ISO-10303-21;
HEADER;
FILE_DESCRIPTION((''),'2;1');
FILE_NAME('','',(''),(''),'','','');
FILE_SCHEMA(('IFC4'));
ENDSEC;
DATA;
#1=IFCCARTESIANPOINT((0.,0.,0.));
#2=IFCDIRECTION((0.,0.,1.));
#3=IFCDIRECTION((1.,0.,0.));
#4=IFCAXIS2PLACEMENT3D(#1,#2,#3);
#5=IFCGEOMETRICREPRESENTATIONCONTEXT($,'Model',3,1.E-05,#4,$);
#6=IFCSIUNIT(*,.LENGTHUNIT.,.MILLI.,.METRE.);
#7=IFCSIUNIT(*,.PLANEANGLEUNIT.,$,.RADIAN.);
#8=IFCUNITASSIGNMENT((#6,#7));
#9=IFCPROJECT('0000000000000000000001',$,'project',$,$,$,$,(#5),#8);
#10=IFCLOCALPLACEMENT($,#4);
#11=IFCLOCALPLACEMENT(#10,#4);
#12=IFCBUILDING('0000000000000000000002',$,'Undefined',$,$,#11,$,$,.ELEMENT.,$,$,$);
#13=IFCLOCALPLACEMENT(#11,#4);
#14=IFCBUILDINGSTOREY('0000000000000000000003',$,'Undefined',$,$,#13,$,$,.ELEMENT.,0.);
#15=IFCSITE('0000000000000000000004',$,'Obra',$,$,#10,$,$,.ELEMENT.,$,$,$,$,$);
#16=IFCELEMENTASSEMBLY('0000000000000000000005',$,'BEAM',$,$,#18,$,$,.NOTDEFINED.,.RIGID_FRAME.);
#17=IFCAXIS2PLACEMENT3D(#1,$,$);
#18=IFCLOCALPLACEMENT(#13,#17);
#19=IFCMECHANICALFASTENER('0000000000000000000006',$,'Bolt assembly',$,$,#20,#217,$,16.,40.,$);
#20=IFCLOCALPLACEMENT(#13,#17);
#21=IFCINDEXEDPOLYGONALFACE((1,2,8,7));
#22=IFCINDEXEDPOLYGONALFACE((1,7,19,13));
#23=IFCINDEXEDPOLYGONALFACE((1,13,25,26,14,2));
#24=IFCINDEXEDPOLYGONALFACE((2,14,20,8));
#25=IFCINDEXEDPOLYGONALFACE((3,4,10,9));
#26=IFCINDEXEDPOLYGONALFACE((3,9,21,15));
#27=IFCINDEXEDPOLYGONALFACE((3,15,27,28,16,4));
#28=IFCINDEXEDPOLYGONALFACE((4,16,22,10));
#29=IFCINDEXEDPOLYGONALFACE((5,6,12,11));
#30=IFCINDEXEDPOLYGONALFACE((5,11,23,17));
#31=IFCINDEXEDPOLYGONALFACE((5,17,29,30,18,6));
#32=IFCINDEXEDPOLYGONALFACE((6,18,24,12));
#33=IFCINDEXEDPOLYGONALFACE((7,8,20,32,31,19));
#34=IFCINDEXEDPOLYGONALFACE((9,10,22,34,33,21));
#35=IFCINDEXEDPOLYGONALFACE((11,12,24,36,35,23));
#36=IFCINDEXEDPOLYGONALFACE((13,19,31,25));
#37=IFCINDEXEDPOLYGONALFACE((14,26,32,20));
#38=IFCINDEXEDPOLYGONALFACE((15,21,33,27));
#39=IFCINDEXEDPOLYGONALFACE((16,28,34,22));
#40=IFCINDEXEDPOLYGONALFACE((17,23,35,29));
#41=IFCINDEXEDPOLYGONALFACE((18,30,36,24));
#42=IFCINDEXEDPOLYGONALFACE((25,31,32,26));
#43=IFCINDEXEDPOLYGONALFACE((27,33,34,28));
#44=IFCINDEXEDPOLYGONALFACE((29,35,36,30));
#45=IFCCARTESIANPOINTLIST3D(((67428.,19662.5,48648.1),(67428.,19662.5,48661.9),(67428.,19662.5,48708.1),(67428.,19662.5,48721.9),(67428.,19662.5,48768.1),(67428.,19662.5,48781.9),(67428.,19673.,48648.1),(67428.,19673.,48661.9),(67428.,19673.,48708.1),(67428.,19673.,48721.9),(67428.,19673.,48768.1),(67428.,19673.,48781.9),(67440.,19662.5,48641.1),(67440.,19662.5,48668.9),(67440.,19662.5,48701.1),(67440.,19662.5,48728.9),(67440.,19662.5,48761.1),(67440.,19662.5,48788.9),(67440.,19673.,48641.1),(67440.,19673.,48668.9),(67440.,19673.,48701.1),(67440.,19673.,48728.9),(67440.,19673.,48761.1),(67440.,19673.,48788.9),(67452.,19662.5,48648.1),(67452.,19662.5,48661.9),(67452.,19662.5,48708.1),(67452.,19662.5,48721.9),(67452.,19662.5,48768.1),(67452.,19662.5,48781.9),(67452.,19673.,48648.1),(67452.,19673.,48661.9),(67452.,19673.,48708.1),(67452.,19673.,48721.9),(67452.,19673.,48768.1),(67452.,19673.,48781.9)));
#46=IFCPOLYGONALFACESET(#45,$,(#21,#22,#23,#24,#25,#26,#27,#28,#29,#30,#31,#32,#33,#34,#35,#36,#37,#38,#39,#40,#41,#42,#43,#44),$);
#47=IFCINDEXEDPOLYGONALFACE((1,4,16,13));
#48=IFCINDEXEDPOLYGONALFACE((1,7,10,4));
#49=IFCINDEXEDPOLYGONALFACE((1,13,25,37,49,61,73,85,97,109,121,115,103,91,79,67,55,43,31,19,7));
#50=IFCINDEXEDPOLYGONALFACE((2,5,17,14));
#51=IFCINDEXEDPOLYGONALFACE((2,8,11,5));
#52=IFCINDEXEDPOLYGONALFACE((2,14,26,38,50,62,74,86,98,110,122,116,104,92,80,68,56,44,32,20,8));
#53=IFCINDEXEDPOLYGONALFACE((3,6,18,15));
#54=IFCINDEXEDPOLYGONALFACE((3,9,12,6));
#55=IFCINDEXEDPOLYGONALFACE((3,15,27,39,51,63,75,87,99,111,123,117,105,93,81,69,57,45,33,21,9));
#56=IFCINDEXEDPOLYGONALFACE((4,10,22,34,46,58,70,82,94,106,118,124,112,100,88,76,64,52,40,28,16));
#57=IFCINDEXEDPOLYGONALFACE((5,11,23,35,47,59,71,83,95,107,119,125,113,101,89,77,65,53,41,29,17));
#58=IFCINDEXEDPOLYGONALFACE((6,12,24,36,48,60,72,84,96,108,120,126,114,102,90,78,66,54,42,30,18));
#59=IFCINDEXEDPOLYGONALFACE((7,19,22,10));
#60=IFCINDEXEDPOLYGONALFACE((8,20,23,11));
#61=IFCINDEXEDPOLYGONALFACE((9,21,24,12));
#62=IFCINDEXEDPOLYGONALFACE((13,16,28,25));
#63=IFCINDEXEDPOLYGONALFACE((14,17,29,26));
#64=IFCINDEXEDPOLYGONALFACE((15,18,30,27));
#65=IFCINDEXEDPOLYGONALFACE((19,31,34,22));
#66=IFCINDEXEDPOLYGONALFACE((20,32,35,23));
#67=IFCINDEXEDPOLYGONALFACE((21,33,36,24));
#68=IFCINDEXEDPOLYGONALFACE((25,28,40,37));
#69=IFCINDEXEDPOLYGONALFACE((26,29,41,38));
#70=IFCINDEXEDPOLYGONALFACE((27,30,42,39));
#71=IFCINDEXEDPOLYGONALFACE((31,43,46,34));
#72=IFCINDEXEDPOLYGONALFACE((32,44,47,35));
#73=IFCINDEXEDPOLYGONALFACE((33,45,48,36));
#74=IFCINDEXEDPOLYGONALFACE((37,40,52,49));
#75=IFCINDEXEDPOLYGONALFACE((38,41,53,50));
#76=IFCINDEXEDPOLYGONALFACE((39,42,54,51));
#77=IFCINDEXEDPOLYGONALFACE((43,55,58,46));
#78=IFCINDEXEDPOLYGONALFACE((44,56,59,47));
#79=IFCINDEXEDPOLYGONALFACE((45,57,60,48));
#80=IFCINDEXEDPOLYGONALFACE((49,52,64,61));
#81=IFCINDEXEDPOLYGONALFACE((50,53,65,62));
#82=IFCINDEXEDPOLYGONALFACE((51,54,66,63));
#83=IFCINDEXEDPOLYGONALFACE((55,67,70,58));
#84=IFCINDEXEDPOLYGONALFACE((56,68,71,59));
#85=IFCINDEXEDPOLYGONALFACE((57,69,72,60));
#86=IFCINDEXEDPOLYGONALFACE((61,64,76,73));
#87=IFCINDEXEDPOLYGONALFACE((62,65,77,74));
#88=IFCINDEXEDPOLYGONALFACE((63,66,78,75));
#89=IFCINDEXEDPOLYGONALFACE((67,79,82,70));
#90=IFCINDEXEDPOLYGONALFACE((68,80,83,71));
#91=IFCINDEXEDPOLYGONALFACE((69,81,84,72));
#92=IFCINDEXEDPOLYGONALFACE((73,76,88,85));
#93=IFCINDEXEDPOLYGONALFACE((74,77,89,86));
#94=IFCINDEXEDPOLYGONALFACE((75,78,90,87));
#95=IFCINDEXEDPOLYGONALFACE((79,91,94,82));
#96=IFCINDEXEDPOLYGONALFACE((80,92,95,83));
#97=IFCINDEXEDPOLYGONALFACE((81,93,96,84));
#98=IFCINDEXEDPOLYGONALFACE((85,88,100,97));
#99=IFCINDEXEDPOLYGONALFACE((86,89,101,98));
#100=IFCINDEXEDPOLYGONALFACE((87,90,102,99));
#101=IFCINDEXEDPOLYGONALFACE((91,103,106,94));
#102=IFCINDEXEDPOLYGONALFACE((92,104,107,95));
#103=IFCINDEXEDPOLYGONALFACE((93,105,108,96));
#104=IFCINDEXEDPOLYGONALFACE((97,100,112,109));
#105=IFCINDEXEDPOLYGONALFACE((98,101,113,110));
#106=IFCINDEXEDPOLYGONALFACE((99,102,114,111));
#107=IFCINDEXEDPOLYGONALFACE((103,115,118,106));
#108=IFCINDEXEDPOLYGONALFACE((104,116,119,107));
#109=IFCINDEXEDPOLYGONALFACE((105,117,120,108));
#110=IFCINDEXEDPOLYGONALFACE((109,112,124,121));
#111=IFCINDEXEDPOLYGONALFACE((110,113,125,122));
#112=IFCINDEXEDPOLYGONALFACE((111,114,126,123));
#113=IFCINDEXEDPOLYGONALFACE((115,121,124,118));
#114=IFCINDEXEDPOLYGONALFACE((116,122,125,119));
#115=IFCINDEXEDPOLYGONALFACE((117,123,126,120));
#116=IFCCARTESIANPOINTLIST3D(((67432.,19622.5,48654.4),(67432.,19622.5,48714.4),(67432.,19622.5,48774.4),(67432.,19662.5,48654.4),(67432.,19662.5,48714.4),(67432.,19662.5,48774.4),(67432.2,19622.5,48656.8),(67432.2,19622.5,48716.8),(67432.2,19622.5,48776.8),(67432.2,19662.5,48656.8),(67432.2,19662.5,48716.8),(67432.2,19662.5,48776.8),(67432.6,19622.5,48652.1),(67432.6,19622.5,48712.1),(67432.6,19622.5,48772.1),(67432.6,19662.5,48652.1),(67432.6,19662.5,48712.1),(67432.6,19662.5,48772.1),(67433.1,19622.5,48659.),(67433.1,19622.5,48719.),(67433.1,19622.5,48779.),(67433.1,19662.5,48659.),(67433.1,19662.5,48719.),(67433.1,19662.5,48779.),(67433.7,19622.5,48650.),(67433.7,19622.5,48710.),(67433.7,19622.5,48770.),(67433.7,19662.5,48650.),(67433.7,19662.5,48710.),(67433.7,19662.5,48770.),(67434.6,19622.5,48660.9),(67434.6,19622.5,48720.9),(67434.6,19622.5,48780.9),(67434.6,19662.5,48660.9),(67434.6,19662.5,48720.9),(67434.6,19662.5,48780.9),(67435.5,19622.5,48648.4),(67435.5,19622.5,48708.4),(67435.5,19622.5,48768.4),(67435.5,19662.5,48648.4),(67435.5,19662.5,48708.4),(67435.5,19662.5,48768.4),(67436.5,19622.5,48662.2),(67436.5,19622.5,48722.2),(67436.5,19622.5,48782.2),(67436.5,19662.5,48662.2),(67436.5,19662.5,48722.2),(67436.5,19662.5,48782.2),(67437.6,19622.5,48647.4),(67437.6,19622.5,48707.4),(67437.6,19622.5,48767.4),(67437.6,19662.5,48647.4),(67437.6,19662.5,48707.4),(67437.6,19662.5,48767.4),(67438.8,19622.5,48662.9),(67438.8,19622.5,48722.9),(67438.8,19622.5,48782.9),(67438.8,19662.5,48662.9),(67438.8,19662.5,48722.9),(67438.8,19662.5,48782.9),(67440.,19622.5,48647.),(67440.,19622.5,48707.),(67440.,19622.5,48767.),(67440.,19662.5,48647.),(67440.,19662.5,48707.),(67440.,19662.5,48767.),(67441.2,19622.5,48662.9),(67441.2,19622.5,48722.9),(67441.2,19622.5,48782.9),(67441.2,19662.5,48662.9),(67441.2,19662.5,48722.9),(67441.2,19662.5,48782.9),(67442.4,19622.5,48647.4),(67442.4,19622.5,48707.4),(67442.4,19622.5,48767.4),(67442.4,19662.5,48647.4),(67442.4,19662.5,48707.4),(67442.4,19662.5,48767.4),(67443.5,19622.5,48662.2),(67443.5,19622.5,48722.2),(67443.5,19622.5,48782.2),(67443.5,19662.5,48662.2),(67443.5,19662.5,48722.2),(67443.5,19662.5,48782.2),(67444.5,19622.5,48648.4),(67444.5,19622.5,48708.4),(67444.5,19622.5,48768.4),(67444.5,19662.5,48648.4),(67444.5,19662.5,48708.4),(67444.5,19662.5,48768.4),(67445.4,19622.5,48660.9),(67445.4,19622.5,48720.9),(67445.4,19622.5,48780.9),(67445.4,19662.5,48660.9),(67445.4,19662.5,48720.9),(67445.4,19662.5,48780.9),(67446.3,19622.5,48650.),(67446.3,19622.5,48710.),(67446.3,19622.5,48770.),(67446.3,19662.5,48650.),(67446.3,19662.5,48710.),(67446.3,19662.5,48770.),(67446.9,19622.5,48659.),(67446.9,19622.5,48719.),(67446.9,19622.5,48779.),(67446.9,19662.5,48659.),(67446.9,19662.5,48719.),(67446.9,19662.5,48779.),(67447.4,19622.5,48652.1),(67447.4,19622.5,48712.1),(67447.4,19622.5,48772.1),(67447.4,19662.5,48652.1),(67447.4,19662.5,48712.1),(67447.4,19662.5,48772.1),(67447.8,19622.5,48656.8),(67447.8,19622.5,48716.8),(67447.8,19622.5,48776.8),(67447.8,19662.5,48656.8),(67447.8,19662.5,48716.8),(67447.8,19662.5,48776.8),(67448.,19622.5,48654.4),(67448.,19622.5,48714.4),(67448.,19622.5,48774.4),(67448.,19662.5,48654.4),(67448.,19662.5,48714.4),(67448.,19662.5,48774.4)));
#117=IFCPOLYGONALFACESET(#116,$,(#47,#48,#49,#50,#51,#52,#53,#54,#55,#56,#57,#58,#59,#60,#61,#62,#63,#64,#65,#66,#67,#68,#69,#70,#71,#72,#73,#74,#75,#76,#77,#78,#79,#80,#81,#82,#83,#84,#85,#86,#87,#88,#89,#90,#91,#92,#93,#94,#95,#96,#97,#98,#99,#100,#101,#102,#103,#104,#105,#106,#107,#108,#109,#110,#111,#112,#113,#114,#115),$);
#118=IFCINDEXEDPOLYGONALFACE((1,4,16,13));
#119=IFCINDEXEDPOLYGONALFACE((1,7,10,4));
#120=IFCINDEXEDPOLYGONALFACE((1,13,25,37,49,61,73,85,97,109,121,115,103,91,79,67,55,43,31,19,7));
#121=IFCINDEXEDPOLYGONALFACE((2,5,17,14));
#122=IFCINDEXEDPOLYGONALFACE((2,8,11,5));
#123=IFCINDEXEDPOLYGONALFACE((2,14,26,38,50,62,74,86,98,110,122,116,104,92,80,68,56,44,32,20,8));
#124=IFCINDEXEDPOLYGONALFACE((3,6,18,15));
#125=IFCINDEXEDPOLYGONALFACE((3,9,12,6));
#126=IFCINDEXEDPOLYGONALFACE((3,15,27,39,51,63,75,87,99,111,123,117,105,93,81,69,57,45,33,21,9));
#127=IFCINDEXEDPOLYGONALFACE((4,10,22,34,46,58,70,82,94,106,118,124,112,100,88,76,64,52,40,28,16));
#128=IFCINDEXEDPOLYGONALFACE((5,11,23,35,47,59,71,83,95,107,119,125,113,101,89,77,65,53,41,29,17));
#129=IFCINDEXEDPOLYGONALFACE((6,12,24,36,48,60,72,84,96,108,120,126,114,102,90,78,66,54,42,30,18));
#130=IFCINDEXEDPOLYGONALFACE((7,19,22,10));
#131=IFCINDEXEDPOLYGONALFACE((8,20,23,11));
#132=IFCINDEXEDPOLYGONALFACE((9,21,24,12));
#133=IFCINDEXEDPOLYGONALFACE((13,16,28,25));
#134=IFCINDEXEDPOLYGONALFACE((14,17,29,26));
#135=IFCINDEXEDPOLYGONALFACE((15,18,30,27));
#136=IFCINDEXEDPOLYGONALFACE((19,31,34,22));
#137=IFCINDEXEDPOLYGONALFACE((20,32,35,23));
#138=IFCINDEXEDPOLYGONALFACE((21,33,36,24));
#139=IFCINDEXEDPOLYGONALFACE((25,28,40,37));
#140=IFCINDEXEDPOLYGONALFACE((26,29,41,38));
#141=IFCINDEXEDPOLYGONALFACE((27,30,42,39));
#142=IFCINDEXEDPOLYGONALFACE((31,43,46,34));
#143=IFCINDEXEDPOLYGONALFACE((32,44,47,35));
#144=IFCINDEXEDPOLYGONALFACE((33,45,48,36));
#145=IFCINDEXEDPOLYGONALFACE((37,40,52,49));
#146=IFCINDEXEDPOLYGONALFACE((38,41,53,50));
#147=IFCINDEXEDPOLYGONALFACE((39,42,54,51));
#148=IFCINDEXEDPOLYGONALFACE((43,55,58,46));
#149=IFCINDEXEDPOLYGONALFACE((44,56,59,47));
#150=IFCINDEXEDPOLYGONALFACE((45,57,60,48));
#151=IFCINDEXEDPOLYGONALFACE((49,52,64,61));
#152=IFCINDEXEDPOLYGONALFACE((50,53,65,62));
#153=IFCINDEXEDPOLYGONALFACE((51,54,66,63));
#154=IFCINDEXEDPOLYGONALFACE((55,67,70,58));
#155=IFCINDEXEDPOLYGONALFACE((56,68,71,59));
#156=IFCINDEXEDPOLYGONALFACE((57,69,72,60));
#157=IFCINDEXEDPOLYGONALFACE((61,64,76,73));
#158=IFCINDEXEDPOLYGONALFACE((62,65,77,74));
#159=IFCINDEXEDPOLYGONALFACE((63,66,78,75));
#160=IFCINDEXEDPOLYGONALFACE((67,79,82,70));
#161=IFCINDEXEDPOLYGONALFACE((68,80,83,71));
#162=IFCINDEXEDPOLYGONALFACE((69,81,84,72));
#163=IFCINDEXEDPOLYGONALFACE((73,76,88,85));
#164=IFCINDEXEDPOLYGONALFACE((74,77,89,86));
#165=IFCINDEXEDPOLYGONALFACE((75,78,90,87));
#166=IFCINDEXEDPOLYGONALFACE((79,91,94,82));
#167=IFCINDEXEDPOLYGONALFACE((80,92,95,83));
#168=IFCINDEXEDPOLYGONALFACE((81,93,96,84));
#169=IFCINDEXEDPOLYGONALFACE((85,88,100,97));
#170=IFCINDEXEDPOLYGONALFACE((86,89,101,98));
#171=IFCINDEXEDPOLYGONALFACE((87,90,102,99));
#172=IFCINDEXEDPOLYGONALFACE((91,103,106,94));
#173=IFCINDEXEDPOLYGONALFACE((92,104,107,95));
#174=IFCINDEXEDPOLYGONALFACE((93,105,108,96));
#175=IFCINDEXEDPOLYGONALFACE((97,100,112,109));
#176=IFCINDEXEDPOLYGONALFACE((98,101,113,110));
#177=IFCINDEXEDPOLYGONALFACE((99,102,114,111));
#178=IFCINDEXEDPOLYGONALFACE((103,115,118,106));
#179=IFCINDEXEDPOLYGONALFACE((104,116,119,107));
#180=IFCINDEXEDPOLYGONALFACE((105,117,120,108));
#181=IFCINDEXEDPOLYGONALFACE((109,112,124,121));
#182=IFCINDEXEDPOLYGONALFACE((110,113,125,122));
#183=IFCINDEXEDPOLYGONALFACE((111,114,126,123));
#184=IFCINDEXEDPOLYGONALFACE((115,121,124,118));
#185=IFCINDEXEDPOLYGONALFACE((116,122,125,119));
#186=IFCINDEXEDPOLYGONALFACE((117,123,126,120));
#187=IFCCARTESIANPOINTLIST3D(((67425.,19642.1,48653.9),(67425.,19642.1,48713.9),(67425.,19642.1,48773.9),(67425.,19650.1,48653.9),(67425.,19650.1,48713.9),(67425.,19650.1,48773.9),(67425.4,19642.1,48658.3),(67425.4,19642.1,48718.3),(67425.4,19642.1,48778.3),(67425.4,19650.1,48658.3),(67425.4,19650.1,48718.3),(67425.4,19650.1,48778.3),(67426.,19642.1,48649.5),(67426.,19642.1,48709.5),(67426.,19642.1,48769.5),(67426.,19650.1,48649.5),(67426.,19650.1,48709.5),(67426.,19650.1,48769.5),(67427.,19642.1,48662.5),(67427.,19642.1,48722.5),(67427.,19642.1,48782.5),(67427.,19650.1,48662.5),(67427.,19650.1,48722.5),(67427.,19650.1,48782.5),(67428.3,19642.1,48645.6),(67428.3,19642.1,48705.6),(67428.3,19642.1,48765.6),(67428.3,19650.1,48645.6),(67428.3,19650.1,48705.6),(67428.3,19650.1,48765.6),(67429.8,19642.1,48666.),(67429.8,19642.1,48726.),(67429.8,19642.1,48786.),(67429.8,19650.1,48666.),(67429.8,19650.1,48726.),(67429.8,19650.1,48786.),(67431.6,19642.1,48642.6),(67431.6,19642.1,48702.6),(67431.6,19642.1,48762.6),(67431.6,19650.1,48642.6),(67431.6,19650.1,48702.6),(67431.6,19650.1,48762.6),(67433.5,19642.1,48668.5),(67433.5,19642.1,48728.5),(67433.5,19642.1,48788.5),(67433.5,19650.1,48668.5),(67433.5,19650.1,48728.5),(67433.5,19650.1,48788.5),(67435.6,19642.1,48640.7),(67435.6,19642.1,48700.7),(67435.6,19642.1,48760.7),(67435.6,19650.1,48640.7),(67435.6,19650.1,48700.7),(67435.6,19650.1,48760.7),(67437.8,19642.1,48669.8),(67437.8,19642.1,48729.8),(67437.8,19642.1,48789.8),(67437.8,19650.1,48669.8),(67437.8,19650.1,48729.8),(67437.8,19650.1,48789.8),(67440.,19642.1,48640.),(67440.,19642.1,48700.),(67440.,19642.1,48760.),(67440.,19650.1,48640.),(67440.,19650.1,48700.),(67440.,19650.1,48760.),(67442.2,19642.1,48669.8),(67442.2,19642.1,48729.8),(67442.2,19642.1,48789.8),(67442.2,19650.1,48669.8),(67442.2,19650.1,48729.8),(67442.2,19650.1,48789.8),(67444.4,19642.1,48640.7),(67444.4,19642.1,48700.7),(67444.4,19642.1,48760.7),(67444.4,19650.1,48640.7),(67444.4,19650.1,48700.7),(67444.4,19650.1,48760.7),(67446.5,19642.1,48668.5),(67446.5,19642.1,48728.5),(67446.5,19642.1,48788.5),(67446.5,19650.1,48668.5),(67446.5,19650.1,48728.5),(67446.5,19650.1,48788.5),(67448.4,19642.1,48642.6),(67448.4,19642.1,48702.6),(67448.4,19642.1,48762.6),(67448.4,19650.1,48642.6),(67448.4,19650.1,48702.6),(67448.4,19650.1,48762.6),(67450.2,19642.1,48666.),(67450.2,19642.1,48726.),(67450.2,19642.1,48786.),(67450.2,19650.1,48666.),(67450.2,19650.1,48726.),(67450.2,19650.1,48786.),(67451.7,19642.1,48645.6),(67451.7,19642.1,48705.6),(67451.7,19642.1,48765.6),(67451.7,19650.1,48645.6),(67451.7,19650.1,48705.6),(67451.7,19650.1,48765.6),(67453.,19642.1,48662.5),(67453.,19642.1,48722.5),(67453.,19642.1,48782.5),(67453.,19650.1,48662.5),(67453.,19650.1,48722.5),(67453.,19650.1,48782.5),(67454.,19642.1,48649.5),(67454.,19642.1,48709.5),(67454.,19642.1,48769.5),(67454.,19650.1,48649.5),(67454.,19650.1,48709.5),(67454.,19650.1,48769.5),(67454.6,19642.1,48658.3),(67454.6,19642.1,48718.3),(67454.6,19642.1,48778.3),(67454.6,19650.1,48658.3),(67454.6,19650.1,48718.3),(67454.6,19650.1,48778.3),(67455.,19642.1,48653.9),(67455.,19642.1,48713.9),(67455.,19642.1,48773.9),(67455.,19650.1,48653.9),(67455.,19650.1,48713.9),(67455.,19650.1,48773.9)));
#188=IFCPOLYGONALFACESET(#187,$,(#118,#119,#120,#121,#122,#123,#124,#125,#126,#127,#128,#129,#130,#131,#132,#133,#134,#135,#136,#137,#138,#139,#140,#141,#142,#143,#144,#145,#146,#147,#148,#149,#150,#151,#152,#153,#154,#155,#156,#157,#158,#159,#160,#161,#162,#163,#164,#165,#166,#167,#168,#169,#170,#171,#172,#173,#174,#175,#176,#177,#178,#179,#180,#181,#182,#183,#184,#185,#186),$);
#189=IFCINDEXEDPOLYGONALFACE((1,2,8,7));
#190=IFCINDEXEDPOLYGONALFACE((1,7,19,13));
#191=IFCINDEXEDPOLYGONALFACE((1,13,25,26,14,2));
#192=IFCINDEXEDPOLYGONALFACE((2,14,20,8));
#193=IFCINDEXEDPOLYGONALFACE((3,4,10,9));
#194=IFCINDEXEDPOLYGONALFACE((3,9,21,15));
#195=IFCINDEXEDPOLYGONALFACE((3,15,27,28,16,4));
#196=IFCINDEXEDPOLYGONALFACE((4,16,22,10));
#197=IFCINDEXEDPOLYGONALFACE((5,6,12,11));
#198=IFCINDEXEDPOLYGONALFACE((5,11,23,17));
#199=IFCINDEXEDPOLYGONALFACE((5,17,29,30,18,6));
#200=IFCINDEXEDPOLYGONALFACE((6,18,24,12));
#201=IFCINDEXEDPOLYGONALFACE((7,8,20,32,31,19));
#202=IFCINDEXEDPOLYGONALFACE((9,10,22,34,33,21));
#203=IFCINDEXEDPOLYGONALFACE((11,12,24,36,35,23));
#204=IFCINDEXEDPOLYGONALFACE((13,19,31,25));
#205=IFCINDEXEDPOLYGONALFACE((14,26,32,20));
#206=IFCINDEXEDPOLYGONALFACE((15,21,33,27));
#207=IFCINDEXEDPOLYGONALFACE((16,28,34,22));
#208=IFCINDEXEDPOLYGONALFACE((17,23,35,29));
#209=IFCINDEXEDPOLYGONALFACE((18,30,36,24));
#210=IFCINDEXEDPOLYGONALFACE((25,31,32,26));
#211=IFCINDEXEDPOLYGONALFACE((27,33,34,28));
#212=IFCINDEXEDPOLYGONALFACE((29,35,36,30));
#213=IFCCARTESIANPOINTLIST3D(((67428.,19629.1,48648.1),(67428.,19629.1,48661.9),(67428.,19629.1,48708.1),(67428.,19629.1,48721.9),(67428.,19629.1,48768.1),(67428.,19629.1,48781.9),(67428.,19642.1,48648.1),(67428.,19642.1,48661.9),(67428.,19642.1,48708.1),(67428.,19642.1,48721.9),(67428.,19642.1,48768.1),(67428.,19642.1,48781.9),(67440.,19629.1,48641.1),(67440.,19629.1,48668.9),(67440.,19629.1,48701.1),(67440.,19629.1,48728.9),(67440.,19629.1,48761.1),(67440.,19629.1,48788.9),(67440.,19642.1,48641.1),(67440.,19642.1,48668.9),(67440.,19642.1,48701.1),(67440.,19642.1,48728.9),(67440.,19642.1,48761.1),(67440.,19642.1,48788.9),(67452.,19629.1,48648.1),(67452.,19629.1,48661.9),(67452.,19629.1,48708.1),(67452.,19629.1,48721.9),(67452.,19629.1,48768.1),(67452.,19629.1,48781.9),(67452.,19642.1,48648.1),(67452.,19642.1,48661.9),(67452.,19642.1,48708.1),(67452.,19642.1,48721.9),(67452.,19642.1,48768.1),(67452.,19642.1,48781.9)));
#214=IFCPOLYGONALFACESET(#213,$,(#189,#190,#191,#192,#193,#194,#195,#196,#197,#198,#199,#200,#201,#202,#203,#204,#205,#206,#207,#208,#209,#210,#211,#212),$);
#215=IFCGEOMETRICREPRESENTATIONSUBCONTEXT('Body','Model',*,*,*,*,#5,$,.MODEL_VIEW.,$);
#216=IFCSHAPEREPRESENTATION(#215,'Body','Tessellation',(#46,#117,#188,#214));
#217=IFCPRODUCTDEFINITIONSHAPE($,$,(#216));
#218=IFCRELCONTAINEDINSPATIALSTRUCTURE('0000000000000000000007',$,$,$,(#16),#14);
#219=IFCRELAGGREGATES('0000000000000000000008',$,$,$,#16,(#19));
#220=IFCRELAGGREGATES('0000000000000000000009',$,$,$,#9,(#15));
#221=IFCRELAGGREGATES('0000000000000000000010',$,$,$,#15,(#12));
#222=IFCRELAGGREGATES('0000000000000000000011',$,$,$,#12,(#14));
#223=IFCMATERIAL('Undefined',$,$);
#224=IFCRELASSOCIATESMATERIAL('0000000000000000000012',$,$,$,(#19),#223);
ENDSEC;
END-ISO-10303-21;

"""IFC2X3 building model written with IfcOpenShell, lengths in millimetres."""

from ifc_helpers import new_model, si_unit, frame, origin_with_axes, origin_2d_with_axis, place, context, subcontext, project, spatial, polyline, circle, outline, extrude, source, transform, mapped, material, element, aggregate, save


model = new_model("IFC2X3")

# Units and contexts
model_context = context("Model", 3, precision=1e-05, world=origin_with_axes())
body_context = subcontext(model_context, "Body", "Model", "MODEL_VIEW")
ifc_project = project(units=[si_unit("LENGTHUNIT", "METRE", prefix="MILLI"), si_unit("PLANEANGLEUNIT", "RADIAN")], contexts=[model_context])

# Site, building, storey
site_placement = place(None, origin_with_axes())
site = spatial("IfcSite", under=ifc_project, at=site_placement, Name="Obra", CompositionType="ELEMENT")
building_placement = place(site_placement, origin_with_axes())
building = spatial("IfcBuilding", under=site, at=building_placement, Name="Undefined", CompositionType="ELEMENT")
storey_placement = place(building_placement, origin_with_axes())
storey = spatial("IfcBuildingStorey", under=building, at=storey_placement, Name="Undefined", CompositionType="ELEMENT", Elevation=0.0)

# Element assembly, mechanical fastener
ifc_material_1 = material(Name="Undefined")
assembly_1_placement = place(storey_placement, origin_with_axes())
assembly_1 = element("IfcElementAssembly", 1, at=assembly_1_placement, inside=storey, Name="BEAM", AssemblyPlace="NOTDEFINED", PredefinedType="RIGID_FRAME")
shared_shape_1 = source(origin_with_axes(), body_context, "Body", "SweptSolid", [
    extrude(outline(polyline([(13.9, 0.0), (6.9, 12.0), (-6.9, 12.0), (-13.9, 0.0), (-6.9, -12.0), (6.9, -12.0), (13.9, 0.0)])), frame((0.0, -19.7, 0.0), z_axis=(0.0, 1.0, 0.0), x_axis=(1.0, 0.0, 0.0)), (0.0, 0.0, 1.0), 10.6),
    extrude(circle(Radius=8.0, at=origin_2d_with_axis()), frame((0.0, -9.1, 0.0), z_axis=(0.0, 1.0, 0.0), x_axis=(1.0, 0.0, 0.0)), (0.0, 0.0, 1.0), 40.0),
    extrude(circle(Radius=15.0, at=origin_2d_with_axis()), frame((0.0, 3.3, 0.0), z_axis=(0.0, 1.0, 0.0), x_axis=(1.0, 0.0, 0.0)), (0.0, 0.0, 1.0), 8.0),
    extrude(outline(polyline([(13.9, 0.0), (6.9, 12.0), (-6.9, 12.0), (-13.9, 0.0), (-6.9, -12.0), (6.9, -12.0), (13.9, 0.0)])), frame((0.0, 11.3, 0.0), z_axis=(0.0, 1.0, 0.0), x_axis=(1.0, 0.0, 0.0)), (0.0, 0.0, 1.0), 13.0),
])
mechanical_fastener_1_placement = place(assembly_1_placement, frame((67490.0, 19653.4, 48835.0), z_axis=(-1.0, 0.0, 0.0), x_axis=(0.0, 0.0, -1.0)))
mechanical_fastener_1 = element("IfcMechanicalFastener", 2, at=mechanical_fastener_1_placement, material=ifc_material_1, Name="Bolt assembly", NominalDiameter=16.0, NominalLength=40.0, context=body_context, shape_type="MappedRepresentation", body=[
    mapped(shared_shape_1, transform((60.0, 0.0, 50.0))),
    mapped(shared_shape_1, transform((120.0, 0.0, 50.0))),
    mapped(shared_shape_1, transform((180.0, 0.0, 50.0))),
])
aggregate(assembly_1, [mechanical_fastener_1])

save(model, "model.ifc")
